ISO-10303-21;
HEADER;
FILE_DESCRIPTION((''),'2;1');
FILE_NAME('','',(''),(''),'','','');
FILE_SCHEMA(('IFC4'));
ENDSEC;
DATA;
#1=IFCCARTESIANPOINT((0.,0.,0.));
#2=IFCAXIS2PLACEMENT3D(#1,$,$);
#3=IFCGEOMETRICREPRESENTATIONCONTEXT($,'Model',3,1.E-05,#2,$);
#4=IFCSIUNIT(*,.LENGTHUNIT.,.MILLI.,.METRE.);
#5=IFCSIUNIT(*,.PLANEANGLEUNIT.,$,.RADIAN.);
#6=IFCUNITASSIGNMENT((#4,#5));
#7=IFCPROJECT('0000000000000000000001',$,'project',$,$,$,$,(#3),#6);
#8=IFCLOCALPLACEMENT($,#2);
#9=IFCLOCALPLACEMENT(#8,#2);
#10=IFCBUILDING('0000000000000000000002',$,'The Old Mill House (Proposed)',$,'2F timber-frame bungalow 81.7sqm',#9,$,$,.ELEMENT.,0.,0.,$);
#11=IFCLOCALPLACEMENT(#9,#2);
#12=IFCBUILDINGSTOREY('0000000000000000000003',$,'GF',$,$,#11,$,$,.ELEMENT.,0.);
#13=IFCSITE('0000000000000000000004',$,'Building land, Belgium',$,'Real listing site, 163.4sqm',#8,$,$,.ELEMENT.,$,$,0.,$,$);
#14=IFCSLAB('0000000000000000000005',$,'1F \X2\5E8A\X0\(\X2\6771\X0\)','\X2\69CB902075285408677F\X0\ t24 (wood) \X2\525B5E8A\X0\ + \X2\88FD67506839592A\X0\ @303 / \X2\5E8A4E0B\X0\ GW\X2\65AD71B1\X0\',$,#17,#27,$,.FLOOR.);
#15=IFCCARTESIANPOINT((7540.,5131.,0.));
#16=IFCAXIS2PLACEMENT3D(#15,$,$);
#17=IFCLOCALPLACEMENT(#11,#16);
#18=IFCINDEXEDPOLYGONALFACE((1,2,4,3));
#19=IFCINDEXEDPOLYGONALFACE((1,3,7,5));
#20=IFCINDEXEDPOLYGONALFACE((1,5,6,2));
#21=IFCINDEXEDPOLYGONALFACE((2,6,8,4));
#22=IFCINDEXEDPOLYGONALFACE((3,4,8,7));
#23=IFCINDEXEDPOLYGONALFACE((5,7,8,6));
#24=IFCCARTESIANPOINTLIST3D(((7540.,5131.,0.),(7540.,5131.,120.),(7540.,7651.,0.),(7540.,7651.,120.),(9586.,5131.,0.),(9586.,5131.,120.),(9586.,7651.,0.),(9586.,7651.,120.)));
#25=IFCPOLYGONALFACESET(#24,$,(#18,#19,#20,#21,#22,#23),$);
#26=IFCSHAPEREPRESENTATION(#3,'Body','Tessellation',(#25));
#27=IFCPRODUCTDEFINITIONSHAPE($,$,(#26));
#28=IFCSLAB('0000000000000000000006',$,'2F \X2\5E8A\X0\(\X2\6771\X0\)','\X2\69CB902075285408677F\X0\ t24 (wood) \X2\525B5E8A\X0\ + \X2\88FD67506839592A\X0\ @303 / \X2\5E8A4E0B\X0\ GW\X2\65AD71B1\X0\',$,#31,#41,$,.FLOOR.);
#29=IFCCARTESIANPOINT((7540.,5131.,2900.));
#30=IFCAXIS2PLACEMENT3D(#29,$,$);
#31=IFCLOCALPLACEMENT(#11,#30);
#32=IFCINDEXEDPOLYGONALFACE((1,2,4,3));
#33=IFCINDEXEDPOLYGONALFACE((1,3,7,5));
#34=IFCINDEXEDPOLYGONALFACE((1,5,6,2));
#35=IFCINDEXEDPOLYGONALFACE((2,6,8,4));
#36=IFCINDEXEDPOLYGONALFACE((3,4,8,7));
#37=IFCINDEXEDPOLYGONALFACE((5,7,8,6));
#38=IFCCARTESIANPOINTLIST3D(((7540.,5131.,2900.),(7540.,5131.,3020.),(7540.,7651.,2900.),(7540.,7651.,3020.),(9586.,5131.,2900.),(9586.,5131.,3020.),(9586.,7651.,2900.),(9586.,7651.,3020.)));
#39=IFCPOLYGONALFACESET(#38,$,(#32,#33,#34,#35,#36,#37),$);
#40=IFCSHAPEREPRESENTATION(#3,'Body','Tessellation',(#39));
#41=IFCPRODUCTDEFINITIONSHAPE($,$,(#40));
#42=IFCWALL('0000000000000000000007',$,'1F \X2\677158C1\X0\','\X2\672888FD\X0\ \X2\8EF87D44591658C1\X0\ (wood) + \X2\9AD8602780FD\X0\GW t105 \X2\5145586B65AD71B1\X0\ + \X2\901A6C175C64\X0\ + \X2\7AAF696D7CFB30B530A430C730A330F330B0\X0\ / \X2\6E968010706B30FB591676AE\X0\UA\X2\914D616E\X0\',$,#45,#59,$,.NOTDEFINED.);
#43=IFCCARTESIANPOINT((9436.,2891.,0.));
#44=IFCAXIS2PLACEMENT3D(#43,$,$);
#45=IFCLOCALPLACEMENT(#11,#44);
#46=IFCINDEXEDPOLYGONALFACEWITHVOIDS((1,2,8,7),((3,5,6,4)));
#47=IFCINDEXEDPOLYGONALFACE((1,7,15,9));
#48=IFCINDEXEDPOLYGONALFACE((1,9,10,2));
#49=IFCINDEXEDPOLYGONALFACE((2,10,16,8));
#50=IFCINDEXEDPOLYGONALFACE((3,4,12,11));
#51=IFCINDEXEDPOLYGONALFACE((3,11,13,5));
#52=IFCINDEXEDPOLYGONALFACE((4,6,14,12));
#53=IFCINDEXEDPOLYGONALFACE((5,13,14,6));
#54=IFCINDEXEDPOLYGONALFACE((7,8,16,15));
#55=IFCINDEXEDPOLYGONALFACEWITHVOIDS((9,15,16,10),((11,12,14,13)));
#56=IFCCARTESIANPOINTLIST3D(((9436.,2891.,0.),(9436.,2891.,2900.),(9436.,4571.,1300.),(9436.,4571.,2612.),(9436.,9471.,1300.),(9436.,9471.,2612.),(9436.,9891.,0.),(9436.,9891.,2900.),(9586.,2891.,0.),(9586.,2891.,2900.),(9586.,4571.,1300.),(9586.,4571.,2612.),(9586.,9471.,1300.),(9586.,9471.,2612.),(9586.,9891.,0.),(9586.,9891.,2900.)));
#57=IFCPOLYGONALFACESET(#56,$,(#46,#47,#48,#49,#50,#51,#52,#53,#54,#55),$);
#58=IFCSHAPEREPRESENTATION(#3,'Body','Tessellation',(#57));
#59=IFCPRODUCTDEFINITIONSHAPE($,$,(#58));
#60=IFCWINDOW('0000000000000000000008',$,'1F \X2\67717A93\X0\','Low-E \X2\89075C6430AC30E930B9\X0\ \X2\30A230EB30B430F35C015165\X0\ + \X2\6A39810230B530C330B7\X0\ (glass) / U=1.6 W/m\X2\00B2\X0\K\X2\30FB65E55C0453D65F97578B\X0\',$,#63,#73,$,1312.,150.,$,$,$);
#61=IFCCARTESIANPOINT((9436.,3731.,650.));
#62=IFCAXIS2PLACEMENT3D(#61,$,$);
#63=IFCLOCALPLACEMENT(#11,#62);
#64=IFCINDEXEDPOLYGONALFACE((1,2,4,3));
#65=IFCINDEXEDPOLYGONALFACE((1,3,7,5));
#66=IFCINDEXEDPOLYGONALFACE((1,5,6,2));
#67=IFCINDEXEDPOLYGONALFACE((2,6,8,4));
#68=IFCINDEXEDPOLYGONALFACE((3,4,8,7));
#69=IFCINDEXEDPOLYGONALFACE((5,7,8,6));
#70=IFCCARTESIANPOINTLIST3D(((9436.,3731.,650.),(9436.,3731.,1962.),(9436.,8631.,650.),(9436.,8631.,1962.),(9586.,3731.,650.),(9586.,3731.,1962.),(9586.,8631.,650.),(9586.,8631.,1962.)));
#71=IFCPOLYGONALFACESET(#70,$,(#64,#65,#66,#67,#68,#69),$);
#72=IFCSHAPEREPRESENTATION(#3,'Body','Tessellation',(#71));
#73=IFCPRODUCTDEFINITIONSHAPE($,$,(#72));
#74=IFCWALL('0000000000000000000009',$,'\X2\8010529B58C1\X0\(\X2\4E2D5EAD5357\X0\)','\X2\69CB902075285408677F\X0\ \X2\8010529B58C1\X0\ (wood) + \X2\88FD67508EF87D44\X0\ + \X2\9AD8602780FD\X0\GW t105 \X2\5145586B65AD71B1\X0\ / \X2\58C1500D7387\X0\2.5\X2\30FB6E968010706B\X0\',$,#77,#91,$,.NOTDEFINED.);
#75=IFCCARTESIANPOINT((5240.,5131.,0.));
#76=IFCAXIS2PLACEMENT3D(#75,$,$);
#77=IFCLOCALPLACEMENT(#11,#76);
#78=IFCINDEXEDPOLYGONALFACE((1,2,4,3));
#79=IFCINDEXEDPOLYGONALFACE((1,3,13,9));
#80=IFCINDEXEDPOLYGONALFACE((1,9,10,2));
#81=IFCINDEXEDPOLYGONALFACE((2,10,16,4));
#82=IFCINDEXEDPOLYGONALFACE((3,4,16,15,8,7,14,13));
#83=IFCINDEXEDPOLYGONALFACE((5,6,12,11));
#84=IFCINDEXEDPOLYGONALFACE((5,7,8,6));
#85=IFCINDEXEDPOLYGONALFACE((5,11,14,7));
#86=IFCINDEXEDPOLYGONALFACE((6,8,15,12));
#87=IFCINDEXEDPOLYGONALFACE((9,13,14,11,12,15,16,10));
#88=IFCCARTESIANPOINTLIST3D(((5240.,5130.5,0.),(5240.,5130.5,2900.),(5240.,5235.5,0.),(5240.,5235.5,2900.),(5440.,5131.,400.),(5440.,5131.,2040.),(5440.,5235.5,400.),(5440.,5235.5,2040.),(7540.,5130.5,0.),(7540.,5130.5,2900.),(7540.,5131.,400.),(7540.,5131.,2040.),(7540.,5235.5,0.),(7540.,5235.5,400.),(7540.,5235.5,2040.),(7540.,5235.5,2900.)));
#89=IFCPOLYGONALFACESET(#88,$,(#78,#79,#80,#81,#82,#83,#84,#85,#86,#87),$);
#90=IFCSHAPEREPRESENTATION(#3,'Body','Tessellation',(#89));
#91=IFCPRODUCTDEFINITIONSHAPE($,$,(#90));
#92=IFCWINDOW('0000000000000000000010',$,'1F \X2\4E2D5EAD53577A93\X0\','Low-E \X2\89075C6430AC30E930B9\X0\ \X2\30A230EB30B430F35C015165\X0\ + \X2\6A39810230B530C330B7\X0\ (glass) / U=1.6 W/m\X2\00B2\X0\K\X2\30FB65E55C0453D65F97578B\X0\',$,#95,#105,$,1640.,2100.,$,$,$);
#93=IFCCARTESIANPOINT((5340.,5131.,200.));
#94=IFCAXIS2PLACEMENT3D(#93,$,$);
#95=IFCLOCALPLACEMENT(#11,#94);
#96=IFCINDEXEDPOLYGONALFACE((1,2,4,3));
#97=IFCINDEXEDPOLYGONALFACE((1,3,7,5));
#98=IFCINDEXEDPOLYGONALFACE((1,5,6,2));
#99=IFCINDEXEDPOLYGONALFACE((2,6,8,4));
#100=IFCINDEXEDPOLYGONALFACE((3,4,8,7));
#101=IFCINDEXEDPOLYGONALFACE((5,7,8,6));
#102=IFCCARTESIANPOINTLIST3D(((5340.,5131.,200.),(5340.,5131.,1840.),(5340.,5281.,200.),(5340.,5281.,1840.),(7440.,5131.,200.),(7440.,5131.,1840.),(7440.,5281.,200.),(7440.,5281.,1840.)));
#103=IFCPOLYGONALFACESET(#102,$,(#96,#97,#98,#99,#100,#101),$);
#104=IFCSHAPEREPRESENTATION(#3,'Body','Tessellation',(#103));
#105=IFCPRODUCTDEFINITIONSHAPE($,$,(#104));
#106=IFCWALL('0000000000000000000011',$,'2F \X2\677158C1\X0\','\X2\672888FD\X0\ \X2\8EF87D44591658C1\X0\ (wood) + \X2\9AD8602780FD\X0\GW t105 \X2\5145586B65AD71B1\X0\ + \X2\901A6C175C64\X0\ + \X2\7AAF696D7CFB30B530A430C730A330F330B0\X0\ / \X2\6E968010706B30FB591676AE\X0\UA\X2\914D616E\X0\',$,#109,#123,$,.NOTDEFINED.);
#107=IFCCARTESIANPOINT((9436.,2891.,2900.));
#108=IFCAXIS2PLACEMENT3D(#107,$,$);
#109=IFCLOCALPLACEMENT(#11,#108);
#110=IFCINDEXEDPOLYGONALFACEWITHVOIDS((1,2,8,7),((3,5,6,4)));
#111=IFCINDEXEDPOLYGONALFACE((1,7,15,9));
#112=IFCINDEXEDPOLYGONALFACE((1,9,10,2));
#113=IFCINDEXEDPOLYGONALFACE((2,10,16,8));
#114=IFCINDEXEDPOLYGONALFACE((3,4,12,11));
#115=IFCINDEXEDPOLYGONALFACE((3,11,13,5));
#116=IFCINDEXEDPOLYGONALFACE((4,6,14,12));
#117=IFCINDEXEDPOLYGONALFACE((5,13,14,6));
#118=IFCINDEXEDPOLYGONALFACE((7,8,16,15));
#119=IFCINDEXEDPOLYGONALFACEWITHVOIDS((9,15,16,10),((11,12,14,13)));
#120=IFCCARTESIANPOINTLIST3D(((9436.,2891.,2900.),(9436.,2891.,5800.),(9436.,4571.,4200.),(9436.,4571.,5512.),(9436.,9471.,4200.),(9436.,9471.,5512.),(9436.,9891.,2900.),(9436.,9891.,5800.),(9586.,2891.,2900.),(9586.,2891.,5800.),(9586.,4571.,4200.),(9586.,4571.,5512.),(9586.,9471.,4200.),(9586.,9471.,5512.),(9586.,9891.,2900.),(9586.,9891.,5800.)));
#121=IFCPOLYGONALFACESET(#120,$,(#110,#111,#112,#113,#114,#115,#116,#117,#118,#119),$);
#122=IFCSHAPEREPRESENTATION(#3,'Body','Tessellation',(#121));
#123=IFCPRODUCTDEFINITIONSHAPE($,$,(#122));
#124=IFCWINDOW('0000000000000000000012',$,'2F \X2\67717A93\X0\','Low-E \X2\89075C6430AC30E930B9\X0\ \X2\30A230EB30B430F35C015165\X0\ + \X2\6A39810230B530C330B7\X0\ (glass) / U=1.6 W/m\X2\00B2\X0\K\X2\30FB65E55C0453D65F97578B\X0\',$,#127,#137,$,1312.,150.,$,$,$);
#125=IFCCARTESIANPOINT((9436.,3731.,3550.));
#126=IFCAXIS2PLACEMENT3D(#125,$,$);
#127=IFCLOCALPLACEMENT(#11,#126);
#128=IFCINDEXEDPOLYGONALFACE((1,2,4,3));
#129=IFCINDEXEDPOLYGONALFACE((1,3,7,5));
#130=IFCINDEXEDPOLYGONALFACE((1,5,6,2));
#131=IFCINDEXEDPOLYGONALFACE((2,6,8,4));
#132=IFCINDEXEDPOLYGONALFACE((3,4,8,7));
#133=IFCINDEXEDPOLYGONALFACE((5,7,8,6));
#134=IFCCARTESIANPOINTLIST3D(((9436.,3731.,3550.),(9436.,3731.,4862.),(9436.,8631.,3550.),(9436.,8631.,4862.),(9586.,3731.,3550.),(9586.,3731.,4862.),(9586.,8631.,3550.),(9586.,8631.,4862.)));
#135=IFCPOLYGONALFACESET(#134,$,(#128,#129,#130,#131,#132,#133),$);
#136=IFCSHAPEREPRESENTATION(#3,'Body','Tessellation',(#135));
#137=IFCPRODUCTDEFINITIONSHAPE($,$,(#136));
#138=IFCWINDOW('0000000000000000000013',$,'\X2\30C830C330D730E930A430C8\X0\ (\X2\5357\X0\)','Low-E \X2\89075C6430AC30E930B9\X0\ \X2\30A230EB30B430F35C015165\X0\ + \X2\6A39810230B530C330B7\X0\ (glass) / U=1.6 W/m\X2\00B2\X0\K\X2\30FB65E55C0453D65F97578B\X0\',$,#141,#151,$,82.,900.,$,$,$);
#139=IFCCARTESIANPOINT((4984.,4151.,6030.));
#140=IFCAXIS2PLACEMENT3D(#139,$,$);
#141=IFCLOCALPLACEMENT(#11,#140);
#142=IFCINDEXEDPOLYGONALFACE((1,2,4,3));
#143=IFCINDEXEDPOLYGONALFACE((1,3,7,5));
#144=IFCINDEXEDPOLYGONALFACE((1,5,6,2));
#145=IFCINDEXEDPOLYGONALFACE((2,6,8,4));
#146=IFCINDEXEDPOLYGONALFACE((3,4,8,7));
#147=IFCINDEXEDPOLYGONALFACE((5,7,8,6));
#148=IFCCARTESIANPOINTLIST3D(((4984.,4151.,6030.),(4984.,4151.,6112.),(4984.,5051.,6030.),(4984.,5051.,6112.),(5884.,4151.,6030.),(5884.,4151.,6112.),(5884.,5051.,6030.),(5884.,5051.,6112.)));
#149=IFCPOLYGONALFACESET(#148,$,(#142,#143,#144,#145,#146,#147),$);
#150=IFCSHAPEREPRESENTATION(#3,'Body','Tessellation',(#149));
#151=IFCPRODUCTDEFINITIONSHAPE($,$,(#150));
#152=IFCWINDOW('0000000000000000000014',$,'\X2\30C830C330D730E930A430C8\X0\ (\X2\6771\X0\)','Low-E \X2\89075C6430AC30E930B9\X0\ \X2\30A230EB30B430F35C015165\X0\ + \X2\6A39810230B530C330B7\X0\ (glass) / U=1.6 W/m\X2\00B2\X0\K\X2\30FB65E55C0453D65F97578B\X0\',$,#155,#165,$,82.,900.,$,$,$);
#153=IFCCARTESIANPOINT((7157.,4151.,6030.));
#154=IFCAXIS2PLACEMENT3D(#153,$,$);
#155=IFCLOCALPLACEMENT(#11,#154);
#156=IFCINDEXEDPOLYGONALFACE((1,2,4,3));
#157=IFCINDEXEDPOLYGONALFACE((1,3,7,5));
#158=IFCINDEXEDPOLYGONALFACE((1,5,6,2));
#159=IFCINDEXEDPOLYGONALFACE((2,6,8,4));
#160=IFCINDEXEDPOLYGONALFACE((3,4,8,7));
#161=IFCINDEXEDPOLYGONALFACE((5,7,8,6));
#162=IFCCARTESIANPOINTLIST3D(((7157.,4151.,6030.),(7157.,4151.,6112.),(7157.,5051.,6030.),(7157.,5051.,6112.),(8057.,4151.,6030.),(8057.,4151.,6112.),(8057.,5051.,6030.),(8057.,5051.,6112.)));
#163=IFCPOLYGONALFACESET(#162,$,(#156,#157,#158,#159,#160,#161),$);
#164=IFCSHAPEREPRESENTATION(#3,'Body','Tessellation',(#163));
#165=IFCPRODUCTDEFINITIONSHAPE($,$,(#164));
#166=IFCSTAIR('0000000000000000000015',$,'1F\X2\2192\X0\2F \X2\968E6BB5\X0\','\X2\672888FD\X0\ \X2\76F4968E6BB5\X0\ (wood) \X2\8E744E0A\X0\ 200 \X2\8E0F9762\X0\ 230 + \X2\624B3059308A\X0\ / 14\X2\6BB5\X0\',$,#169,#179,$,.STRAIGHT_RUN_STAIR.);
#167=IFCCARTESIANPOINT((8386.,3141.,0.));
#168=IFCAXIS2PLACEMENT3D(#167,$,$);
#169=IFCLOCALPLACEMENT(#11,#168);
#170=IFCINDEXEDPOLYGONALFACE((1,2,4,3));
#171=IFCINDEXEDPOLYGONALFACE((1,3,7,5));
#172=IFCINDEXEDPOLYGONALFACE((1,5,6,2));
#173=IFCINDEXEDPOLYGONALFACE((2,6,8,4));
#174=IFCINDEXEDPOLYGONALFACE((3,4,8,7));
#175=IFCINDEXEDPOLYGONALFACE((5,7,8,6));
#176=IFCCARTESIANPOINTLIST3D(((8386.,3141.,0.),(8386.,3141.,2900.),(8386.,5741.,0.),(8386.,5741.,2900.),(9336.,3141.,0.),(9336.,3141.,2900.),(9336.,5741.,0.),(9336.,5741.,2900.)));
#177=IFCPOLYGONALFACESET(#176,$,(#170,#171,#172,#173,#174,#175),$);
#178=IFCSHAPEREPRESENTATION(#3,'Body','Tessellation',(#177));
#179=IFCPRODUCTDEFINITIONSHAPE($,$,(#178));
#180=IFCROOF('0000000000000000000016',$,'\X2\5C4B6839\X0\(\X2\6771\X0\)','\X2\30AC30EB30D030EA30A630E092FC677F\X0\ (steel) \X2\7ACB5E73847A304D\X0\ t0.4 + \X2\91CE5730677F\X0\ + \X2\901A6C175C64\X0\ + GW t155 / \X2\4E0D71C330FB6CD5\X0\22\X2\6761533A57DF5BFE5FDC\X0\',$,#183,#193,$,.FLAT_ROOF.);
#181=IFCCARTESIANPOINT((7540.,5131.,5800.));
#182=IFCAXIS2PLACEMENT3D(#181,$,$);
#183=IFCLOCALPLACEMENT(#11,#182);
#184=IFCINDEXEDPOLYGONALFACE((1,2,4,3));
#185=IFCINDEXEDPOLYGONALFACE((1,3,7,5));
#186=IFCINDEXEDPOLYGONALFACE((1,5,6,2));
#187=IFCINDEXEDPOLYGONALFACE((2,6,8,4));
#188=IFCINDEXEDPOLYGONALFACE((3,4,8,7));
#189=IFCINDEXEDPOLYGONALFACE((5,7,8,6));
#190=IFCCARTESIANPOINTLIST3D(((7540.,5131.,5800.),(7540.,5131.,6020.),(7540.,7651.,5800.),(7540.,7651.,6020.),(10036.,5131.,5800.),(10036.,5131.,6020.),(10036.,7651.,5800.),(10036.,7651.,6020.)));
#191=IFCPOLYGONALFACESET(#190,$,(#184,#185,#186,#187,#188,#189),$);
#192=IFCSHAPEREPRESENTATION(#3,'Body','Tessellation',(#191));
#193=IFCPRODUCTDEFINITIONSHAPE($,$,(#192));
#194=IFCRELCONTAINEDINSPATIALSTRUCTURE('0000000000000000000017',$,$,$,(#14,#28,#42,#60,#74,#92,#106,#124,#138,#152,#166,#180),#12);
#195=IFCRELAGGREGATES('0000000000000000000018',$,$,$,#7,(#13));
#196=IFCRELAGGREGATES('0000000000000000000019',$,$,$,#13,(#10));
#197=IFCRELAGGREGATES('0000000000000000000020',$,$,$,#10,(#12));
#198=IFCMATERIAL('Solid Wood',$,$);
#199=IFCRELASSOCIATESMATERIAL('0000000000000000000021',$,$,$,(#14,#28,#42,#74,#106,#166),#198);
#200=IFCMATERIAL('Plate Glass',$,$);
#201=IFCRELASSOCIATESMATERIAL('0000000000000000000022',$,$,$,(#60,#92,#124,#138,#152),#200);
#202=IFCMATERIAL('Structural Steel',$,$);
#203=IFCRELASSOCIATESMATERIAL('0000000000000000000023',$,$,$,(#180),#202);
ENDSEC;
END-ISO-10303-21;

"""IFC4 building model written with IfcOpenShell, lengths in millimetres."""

from ifc_helpers import new_model, si_unit, frame, frame_2d, origin, place, context, project, spatial, rectangle, extrude, material, element, fill, save


model = new_model("IFC4")

# Units and contexts
model_context = context("Model", 3, precision=1e-05, world=origin())
ifc_project = project(units=[si_unit("LENGTHUNIT", "METRE", prefix="MILLI"), si_unit("PLANEANGLEUNIT", "RADIAN")], contexts=[model_context])

# Site, building, storey
site_placement = place(None, origin())
site = spatial("IfcSite", under=ifc_project, at=site_placement, Name="Building land, Belgium", ObjectType="Real listing site, 163.4sqm", CompositionType="ELEMENT", RefElevation=0.0)
building_placement = place(site_placement, origin())
building = spatial("IfcBuilding", under=site, at=building_placement, Name="The Old Mill House (Proposed)", ObjectType="2F timber-frame bungalow 81.7sqm", CompositionType="ELEMENT", ElevationOfRefHeight=0.0, ElevationOfTerrain=0.0)
storey_placement = place(building_placement, origin())
storey = spatial("IfcBuildingStorey", under=building, at=storey_placement, Name="GF", CompositionType="ELEMENT", Elevation=0.0)

# Slabs
ifc_material_1 = material(Name="Solid Wood")
slab_1_placement = place(storey_placement, frame((7540.0, 5131.0, 0.0)))
element("IfcSlab", 1, at=slab_1_placement, inside=storey, material=ifc_material_1, Name="1F 床(東)", Description="構造用合板 t24 (wood) 剛床 + 製材根太 @303 / 床下 GW断熱", PredefinedType="FLOOR", context=model_context, shape_type="SweptSolid", body=[
    extrude(rectangle(XDim=2046.0, YDim=2520.0, at=frame_2d((1023.0, 1260.0))), frame((7540.0, 5131.0, 0.0)), (0.0, 0.0, 1.0), 120.0),
])
slab_2_placement = place(storey_placement, frame((7540.0, 5131.0, 2900.0)))
element("IfcSlab", 2, at=slab_2_placement, inside=storey, material=ifc_material_1, Name="2F 床(東)", Description="構造用合板 t24 (wood) 剛床 + 製材根太 @303 / 床下 GW断熱", PredefinedType="FLOOR", context=model_context, shape_type="SweptSolid", body=[
    extrude(rectangle(XDim=2046.0, YDim=2520.0, at=frame_2d((1023.0, 1260.0))), frame((7540.0, 5131.0, 2900.0)), (0.0, 0.0, 1.0), 120.0),
])

# Walls, openings, windows
wall_1_placement = place(storey_placement, frame((9436.0, 2891.0, 0.0)))
wall_1 = element("IfcWall", 3, at=wall_1_placement, inside=storey, material=ifc_material_1, Name="1F 東壁", Description="木製 軸組外壁 (wood) + 高性能GW t105 充填断熱 + 通気層 + 窯業系サイディング / 準耐火・外皮UA配慮", PredefinedType="NOTDEFINED", context=model_context, shape_type="SweptSolid", body=[
    extrude(rectangle(XDim=150.0, YDim=7000.0, at=frame_2d((75.0, 3500.0))), frame((9436.0, 2891.0, 0.0)), (0.0, 0.0, 1.0), 2900.0),
])
opening_1_placement = place(storey_placement, frame((9436.0, 3731.0, 650.0)))
opening_1 = element("IfcOpeningElement", 4, at=opening_1_placement, cuts=wall_1, PredefinedType="NOTDEFINED", context=model_context, shape_type="SweptSolid", body=[
    extrude(rectangle(XDim=150.0, YDim=4900.0, at=frame_2d((75.0, 2450.0))), frame((9436.0, 3731.0, 650.0)), (0.0, 0.0, 1.0), 1312.0),
])
ifc_material_2 = material(Name="Plate Glass")
window_1_placement = place(storey_placement, frame((9436.0, 3731.0, 650.0)))
window_1 = element("IfcWindow", 5, at=window_1_placement, inside=storey, material=ifc_material_2, Name="1F 東窓", Description="Low-E 複層ガラス アルゴン封入 + 樹脂サッシ (glass) / U=1.6 W/m²K・日射取得型", OverallHeight=1312.0, OverallWidth=150.0, context=model_context, shape_type="SweptSolid", body=[
    extrude(rectangle(XDim=150.0, YDim=4900.0, at=frame_2d((75.0, 2450.0))), frame((9436.0, 3731.0, 650.0)), (0.0, 0.0, 1.0), 1312.0),
])
fill(opening_1, window_1)
wall_2_placement = place(storey_placement, frame((5240.0, 5131.0, 0.0)))
wall_2 = element("IfcWall", 6, at=wall_2_placement, inside=storey, material=ifc_material_1, Name="耐力壁(中庭南)", Description="構造用合板 耐力壁 (wood) + 製材軸組 + 高性能GW t105 充填断熱 / 壁倍率2.5・準耐火", PredefinedType="NOTDEFINED", context=model_context, shape_type="SweptSolid", body=[
    extrude(rectangle(XDim=2300.0, YDim=105.0, at=frame_2d((1150.0, 52.0))), frame((5240.0, 5131.0, 0.0)), (0.0, 0.0, 1.0), 2900.0),
])
opening_2_placement = place(storey_placement, frame((5340.0, 5131.0, 200.0)))
opening_2 = element("IfcOpeningElement", 7, at=opening_2_placement, cuts=wall_2, PredefinedType="NOTDEFINED", context=model_context, shape_type="SweptSolid", body=[
    extrude(rectangle(XDim=2100.0, YDim=150.0, at=frame_2d((1050.0, 75.0))), frame((5340.0, 5131.0, 200.0)), (0.0, 0.0, 1.0), 1640.0),
])
window_2_placement = place(storey_placement, frame((5340.0, 5131.0, 200.0)))
window_2 = element("IfcWindow", 8, at=window_2_placement, inside=storey, material=ifc_material_2, Name="1F 中庭南窓", Description="Low-E 複層ガラス アルゴン封入 + 樹脂サッシ (glass) / U=1.6 W/m²K・日射取得型", OverallHeight=1640.0, OverallWidth=2100.0, context=model_context, shape_type="SweptSolid", body=[
    extrude(rectangle(XDim=2100.0, YDim=150.0, at=frame_2d((1050.0, 75.0))), frame((5340.0, 5131.0, 200.0)), (0.0, 0.0, 1.0), 1640.0),
])
fill(opening_2, window_2)

# Wall, opening, window
wall_3_placement = place(storey_placement, frame((9436.0, 2891.0, 2900.0)))
wall_3 = element("IfcWall", 9, at=wall_3_placement, inside=storey, material=ifc_material_1, Name="2F 東壁", Description="木製 軸組外壁 (wood) + 高性能GW t105 充填断熱 + 通気層 + 窯業系サイディング / 準耐火・外皮UA配慮", PredefinedType="NOTDEFINED", context=model_context, shape_type="SweptSolid", body=[
    extrude(rectangle(XDim=150.0, YDim=7000.0, at=frame_2d((75.0, 3500.0))), frame((9436.0, 2891.0, 2900.0)), (0.0, 0.0, 1.0), 2900.0),
])
opening_3_placement = place(storey_placement, frame((9436.0, 3731.0, 3550.0)))
opening_3 = element("IfcOpeningElement", 10, at=opening_3_placement, cuts=wall_3, PredefinedType="NOTDEFINED", context=model_context, shape_type="SweptSolid", body=[
    extrude(rectangle(XDim=150.0, YDim=4900.0, at=frame_2d((75.0, 2450.0))), frame((9436.0, 3731.0, 3550.0)), (0.0, 0.0, 1.0), 1312.0),
])
window_3_placement = place(storey_placement, frame((9436.0, 3731.0, 3550.0)))
window_3 = element("IfcWindow", 11, at=window_3_placement, inside=storey, material=ifc_material_2, Name="2F 東窓", Description="Low-E 複層ガラス アルゴン封入 + 樹脂サッシ (glass) / U=1.6 W/m²K・日射取得型", OverallHeight=1312.0, OverallWidth=150.0, context=model_context, shape_type="SweptSolid", body=[
    extrude(rectangle(XDim=150.0, YDim=4900.0, at=frame_2d((75.0, 2450.0))), frame((9436.0, 3731.0, 3550.0)), (0.0, 0.0, 1.0), 1312.0),
])
fill(opening_3, window_3)

# Windows
window_4_placement = place(storey_placement, frame((4984.0, 4151.0, 6030.0)))
element("IfcWindow", 12, at=window_4_placement, inside=storey, material=ifc_material_2, Name="トップライト (南)", Description="Low-E 複層ガラス アルゴン封入 + 樹脂サッシ (glass) / U=1.6 W/m²K・日射取得型", OverallHeight=82.0, OverallWidth=900.0, context=model_context, shape_type="SweptSolid", body=[
    extrude(rectangle(XDim=900.0, YDim=900.0, at=frame_2d((450.0, 450.0))), frame((4984.0, 4151.0, 6030.0)), (0.0, 0.0, 1.0), 82.0),
])
window_5_placement = place(storey_placement, frame((7157.0, 4151.0, 6030.0)))
element("IfcWindow", 13, at=window_5_placement, inside=storey, material=ifc_material_2, Name="トップライト (東)", Description="Low-E 複層ガラス アルゴン封入 + 樹脂サッシ (glass) / U=1.6 W/m²K・日射取得型", OverallHeight=82.0, OverallWidth=900.0, context=model_context, shape_type="SweptSolid", body=[
    extrude(rectangle(XDim=900.0, YDim=900.0, at=frame_2d((450.0, 450.0))), frame((7157.0, 4151.0, 6030.0)), (0.0, 0.0, 1.0), 82.0),
])

# Stair
stair_placement = place(storey_placement, frame((8386.0, 3141.0, 0.0)))
element("IfcStair", 14, at=stair_placement, inside=storey, material=ifc_material_1, Name="1F→2F 階段", Description="木製 直階段 (wood) 蹴上 200 踏面 230 + 手すり / 14段", PredefinedType="STRAIGHT_RUN_STAIR", context=model_context, shape_type="SweptSolid", body=[
    extrude(rectangle(XDim=950.0, YDim=2600.0, at=frame_2d((475.0, 1300.0))), frame((8386.0, 3141.0, 0.0)), (0.0, 0.0, 1.0), 2900.0),
])

# Roof
ifc_material_3 = material(Name="Structural Steel")
roof_placement = place(storey_placement, frame((7540.0, 5131.0, 5800.0)))
element("IfcRoof", 15, at=roof_placement, inside=storey, material=ifc_material_3, Name="屋根(東)", Description="ガルバリウム鋼板 (steel) 立平葺き t0.4 + 野地板 + 通気層 + GW t155 / 不燃・法22条区域対応", PredefinedType="FLAT_ROOF", context=model_context, shape_type="SweptSolid", body=[
    extrude(rectangle(XDim=2496.0, YDim=2520.0, at=frame_2d((1248.0, 1260.0))), frame((7540.0, 5131.0, 5800.0)), (0.0, 0.0, 1.0), 220.0),
])

save(model, "model.ifc")
